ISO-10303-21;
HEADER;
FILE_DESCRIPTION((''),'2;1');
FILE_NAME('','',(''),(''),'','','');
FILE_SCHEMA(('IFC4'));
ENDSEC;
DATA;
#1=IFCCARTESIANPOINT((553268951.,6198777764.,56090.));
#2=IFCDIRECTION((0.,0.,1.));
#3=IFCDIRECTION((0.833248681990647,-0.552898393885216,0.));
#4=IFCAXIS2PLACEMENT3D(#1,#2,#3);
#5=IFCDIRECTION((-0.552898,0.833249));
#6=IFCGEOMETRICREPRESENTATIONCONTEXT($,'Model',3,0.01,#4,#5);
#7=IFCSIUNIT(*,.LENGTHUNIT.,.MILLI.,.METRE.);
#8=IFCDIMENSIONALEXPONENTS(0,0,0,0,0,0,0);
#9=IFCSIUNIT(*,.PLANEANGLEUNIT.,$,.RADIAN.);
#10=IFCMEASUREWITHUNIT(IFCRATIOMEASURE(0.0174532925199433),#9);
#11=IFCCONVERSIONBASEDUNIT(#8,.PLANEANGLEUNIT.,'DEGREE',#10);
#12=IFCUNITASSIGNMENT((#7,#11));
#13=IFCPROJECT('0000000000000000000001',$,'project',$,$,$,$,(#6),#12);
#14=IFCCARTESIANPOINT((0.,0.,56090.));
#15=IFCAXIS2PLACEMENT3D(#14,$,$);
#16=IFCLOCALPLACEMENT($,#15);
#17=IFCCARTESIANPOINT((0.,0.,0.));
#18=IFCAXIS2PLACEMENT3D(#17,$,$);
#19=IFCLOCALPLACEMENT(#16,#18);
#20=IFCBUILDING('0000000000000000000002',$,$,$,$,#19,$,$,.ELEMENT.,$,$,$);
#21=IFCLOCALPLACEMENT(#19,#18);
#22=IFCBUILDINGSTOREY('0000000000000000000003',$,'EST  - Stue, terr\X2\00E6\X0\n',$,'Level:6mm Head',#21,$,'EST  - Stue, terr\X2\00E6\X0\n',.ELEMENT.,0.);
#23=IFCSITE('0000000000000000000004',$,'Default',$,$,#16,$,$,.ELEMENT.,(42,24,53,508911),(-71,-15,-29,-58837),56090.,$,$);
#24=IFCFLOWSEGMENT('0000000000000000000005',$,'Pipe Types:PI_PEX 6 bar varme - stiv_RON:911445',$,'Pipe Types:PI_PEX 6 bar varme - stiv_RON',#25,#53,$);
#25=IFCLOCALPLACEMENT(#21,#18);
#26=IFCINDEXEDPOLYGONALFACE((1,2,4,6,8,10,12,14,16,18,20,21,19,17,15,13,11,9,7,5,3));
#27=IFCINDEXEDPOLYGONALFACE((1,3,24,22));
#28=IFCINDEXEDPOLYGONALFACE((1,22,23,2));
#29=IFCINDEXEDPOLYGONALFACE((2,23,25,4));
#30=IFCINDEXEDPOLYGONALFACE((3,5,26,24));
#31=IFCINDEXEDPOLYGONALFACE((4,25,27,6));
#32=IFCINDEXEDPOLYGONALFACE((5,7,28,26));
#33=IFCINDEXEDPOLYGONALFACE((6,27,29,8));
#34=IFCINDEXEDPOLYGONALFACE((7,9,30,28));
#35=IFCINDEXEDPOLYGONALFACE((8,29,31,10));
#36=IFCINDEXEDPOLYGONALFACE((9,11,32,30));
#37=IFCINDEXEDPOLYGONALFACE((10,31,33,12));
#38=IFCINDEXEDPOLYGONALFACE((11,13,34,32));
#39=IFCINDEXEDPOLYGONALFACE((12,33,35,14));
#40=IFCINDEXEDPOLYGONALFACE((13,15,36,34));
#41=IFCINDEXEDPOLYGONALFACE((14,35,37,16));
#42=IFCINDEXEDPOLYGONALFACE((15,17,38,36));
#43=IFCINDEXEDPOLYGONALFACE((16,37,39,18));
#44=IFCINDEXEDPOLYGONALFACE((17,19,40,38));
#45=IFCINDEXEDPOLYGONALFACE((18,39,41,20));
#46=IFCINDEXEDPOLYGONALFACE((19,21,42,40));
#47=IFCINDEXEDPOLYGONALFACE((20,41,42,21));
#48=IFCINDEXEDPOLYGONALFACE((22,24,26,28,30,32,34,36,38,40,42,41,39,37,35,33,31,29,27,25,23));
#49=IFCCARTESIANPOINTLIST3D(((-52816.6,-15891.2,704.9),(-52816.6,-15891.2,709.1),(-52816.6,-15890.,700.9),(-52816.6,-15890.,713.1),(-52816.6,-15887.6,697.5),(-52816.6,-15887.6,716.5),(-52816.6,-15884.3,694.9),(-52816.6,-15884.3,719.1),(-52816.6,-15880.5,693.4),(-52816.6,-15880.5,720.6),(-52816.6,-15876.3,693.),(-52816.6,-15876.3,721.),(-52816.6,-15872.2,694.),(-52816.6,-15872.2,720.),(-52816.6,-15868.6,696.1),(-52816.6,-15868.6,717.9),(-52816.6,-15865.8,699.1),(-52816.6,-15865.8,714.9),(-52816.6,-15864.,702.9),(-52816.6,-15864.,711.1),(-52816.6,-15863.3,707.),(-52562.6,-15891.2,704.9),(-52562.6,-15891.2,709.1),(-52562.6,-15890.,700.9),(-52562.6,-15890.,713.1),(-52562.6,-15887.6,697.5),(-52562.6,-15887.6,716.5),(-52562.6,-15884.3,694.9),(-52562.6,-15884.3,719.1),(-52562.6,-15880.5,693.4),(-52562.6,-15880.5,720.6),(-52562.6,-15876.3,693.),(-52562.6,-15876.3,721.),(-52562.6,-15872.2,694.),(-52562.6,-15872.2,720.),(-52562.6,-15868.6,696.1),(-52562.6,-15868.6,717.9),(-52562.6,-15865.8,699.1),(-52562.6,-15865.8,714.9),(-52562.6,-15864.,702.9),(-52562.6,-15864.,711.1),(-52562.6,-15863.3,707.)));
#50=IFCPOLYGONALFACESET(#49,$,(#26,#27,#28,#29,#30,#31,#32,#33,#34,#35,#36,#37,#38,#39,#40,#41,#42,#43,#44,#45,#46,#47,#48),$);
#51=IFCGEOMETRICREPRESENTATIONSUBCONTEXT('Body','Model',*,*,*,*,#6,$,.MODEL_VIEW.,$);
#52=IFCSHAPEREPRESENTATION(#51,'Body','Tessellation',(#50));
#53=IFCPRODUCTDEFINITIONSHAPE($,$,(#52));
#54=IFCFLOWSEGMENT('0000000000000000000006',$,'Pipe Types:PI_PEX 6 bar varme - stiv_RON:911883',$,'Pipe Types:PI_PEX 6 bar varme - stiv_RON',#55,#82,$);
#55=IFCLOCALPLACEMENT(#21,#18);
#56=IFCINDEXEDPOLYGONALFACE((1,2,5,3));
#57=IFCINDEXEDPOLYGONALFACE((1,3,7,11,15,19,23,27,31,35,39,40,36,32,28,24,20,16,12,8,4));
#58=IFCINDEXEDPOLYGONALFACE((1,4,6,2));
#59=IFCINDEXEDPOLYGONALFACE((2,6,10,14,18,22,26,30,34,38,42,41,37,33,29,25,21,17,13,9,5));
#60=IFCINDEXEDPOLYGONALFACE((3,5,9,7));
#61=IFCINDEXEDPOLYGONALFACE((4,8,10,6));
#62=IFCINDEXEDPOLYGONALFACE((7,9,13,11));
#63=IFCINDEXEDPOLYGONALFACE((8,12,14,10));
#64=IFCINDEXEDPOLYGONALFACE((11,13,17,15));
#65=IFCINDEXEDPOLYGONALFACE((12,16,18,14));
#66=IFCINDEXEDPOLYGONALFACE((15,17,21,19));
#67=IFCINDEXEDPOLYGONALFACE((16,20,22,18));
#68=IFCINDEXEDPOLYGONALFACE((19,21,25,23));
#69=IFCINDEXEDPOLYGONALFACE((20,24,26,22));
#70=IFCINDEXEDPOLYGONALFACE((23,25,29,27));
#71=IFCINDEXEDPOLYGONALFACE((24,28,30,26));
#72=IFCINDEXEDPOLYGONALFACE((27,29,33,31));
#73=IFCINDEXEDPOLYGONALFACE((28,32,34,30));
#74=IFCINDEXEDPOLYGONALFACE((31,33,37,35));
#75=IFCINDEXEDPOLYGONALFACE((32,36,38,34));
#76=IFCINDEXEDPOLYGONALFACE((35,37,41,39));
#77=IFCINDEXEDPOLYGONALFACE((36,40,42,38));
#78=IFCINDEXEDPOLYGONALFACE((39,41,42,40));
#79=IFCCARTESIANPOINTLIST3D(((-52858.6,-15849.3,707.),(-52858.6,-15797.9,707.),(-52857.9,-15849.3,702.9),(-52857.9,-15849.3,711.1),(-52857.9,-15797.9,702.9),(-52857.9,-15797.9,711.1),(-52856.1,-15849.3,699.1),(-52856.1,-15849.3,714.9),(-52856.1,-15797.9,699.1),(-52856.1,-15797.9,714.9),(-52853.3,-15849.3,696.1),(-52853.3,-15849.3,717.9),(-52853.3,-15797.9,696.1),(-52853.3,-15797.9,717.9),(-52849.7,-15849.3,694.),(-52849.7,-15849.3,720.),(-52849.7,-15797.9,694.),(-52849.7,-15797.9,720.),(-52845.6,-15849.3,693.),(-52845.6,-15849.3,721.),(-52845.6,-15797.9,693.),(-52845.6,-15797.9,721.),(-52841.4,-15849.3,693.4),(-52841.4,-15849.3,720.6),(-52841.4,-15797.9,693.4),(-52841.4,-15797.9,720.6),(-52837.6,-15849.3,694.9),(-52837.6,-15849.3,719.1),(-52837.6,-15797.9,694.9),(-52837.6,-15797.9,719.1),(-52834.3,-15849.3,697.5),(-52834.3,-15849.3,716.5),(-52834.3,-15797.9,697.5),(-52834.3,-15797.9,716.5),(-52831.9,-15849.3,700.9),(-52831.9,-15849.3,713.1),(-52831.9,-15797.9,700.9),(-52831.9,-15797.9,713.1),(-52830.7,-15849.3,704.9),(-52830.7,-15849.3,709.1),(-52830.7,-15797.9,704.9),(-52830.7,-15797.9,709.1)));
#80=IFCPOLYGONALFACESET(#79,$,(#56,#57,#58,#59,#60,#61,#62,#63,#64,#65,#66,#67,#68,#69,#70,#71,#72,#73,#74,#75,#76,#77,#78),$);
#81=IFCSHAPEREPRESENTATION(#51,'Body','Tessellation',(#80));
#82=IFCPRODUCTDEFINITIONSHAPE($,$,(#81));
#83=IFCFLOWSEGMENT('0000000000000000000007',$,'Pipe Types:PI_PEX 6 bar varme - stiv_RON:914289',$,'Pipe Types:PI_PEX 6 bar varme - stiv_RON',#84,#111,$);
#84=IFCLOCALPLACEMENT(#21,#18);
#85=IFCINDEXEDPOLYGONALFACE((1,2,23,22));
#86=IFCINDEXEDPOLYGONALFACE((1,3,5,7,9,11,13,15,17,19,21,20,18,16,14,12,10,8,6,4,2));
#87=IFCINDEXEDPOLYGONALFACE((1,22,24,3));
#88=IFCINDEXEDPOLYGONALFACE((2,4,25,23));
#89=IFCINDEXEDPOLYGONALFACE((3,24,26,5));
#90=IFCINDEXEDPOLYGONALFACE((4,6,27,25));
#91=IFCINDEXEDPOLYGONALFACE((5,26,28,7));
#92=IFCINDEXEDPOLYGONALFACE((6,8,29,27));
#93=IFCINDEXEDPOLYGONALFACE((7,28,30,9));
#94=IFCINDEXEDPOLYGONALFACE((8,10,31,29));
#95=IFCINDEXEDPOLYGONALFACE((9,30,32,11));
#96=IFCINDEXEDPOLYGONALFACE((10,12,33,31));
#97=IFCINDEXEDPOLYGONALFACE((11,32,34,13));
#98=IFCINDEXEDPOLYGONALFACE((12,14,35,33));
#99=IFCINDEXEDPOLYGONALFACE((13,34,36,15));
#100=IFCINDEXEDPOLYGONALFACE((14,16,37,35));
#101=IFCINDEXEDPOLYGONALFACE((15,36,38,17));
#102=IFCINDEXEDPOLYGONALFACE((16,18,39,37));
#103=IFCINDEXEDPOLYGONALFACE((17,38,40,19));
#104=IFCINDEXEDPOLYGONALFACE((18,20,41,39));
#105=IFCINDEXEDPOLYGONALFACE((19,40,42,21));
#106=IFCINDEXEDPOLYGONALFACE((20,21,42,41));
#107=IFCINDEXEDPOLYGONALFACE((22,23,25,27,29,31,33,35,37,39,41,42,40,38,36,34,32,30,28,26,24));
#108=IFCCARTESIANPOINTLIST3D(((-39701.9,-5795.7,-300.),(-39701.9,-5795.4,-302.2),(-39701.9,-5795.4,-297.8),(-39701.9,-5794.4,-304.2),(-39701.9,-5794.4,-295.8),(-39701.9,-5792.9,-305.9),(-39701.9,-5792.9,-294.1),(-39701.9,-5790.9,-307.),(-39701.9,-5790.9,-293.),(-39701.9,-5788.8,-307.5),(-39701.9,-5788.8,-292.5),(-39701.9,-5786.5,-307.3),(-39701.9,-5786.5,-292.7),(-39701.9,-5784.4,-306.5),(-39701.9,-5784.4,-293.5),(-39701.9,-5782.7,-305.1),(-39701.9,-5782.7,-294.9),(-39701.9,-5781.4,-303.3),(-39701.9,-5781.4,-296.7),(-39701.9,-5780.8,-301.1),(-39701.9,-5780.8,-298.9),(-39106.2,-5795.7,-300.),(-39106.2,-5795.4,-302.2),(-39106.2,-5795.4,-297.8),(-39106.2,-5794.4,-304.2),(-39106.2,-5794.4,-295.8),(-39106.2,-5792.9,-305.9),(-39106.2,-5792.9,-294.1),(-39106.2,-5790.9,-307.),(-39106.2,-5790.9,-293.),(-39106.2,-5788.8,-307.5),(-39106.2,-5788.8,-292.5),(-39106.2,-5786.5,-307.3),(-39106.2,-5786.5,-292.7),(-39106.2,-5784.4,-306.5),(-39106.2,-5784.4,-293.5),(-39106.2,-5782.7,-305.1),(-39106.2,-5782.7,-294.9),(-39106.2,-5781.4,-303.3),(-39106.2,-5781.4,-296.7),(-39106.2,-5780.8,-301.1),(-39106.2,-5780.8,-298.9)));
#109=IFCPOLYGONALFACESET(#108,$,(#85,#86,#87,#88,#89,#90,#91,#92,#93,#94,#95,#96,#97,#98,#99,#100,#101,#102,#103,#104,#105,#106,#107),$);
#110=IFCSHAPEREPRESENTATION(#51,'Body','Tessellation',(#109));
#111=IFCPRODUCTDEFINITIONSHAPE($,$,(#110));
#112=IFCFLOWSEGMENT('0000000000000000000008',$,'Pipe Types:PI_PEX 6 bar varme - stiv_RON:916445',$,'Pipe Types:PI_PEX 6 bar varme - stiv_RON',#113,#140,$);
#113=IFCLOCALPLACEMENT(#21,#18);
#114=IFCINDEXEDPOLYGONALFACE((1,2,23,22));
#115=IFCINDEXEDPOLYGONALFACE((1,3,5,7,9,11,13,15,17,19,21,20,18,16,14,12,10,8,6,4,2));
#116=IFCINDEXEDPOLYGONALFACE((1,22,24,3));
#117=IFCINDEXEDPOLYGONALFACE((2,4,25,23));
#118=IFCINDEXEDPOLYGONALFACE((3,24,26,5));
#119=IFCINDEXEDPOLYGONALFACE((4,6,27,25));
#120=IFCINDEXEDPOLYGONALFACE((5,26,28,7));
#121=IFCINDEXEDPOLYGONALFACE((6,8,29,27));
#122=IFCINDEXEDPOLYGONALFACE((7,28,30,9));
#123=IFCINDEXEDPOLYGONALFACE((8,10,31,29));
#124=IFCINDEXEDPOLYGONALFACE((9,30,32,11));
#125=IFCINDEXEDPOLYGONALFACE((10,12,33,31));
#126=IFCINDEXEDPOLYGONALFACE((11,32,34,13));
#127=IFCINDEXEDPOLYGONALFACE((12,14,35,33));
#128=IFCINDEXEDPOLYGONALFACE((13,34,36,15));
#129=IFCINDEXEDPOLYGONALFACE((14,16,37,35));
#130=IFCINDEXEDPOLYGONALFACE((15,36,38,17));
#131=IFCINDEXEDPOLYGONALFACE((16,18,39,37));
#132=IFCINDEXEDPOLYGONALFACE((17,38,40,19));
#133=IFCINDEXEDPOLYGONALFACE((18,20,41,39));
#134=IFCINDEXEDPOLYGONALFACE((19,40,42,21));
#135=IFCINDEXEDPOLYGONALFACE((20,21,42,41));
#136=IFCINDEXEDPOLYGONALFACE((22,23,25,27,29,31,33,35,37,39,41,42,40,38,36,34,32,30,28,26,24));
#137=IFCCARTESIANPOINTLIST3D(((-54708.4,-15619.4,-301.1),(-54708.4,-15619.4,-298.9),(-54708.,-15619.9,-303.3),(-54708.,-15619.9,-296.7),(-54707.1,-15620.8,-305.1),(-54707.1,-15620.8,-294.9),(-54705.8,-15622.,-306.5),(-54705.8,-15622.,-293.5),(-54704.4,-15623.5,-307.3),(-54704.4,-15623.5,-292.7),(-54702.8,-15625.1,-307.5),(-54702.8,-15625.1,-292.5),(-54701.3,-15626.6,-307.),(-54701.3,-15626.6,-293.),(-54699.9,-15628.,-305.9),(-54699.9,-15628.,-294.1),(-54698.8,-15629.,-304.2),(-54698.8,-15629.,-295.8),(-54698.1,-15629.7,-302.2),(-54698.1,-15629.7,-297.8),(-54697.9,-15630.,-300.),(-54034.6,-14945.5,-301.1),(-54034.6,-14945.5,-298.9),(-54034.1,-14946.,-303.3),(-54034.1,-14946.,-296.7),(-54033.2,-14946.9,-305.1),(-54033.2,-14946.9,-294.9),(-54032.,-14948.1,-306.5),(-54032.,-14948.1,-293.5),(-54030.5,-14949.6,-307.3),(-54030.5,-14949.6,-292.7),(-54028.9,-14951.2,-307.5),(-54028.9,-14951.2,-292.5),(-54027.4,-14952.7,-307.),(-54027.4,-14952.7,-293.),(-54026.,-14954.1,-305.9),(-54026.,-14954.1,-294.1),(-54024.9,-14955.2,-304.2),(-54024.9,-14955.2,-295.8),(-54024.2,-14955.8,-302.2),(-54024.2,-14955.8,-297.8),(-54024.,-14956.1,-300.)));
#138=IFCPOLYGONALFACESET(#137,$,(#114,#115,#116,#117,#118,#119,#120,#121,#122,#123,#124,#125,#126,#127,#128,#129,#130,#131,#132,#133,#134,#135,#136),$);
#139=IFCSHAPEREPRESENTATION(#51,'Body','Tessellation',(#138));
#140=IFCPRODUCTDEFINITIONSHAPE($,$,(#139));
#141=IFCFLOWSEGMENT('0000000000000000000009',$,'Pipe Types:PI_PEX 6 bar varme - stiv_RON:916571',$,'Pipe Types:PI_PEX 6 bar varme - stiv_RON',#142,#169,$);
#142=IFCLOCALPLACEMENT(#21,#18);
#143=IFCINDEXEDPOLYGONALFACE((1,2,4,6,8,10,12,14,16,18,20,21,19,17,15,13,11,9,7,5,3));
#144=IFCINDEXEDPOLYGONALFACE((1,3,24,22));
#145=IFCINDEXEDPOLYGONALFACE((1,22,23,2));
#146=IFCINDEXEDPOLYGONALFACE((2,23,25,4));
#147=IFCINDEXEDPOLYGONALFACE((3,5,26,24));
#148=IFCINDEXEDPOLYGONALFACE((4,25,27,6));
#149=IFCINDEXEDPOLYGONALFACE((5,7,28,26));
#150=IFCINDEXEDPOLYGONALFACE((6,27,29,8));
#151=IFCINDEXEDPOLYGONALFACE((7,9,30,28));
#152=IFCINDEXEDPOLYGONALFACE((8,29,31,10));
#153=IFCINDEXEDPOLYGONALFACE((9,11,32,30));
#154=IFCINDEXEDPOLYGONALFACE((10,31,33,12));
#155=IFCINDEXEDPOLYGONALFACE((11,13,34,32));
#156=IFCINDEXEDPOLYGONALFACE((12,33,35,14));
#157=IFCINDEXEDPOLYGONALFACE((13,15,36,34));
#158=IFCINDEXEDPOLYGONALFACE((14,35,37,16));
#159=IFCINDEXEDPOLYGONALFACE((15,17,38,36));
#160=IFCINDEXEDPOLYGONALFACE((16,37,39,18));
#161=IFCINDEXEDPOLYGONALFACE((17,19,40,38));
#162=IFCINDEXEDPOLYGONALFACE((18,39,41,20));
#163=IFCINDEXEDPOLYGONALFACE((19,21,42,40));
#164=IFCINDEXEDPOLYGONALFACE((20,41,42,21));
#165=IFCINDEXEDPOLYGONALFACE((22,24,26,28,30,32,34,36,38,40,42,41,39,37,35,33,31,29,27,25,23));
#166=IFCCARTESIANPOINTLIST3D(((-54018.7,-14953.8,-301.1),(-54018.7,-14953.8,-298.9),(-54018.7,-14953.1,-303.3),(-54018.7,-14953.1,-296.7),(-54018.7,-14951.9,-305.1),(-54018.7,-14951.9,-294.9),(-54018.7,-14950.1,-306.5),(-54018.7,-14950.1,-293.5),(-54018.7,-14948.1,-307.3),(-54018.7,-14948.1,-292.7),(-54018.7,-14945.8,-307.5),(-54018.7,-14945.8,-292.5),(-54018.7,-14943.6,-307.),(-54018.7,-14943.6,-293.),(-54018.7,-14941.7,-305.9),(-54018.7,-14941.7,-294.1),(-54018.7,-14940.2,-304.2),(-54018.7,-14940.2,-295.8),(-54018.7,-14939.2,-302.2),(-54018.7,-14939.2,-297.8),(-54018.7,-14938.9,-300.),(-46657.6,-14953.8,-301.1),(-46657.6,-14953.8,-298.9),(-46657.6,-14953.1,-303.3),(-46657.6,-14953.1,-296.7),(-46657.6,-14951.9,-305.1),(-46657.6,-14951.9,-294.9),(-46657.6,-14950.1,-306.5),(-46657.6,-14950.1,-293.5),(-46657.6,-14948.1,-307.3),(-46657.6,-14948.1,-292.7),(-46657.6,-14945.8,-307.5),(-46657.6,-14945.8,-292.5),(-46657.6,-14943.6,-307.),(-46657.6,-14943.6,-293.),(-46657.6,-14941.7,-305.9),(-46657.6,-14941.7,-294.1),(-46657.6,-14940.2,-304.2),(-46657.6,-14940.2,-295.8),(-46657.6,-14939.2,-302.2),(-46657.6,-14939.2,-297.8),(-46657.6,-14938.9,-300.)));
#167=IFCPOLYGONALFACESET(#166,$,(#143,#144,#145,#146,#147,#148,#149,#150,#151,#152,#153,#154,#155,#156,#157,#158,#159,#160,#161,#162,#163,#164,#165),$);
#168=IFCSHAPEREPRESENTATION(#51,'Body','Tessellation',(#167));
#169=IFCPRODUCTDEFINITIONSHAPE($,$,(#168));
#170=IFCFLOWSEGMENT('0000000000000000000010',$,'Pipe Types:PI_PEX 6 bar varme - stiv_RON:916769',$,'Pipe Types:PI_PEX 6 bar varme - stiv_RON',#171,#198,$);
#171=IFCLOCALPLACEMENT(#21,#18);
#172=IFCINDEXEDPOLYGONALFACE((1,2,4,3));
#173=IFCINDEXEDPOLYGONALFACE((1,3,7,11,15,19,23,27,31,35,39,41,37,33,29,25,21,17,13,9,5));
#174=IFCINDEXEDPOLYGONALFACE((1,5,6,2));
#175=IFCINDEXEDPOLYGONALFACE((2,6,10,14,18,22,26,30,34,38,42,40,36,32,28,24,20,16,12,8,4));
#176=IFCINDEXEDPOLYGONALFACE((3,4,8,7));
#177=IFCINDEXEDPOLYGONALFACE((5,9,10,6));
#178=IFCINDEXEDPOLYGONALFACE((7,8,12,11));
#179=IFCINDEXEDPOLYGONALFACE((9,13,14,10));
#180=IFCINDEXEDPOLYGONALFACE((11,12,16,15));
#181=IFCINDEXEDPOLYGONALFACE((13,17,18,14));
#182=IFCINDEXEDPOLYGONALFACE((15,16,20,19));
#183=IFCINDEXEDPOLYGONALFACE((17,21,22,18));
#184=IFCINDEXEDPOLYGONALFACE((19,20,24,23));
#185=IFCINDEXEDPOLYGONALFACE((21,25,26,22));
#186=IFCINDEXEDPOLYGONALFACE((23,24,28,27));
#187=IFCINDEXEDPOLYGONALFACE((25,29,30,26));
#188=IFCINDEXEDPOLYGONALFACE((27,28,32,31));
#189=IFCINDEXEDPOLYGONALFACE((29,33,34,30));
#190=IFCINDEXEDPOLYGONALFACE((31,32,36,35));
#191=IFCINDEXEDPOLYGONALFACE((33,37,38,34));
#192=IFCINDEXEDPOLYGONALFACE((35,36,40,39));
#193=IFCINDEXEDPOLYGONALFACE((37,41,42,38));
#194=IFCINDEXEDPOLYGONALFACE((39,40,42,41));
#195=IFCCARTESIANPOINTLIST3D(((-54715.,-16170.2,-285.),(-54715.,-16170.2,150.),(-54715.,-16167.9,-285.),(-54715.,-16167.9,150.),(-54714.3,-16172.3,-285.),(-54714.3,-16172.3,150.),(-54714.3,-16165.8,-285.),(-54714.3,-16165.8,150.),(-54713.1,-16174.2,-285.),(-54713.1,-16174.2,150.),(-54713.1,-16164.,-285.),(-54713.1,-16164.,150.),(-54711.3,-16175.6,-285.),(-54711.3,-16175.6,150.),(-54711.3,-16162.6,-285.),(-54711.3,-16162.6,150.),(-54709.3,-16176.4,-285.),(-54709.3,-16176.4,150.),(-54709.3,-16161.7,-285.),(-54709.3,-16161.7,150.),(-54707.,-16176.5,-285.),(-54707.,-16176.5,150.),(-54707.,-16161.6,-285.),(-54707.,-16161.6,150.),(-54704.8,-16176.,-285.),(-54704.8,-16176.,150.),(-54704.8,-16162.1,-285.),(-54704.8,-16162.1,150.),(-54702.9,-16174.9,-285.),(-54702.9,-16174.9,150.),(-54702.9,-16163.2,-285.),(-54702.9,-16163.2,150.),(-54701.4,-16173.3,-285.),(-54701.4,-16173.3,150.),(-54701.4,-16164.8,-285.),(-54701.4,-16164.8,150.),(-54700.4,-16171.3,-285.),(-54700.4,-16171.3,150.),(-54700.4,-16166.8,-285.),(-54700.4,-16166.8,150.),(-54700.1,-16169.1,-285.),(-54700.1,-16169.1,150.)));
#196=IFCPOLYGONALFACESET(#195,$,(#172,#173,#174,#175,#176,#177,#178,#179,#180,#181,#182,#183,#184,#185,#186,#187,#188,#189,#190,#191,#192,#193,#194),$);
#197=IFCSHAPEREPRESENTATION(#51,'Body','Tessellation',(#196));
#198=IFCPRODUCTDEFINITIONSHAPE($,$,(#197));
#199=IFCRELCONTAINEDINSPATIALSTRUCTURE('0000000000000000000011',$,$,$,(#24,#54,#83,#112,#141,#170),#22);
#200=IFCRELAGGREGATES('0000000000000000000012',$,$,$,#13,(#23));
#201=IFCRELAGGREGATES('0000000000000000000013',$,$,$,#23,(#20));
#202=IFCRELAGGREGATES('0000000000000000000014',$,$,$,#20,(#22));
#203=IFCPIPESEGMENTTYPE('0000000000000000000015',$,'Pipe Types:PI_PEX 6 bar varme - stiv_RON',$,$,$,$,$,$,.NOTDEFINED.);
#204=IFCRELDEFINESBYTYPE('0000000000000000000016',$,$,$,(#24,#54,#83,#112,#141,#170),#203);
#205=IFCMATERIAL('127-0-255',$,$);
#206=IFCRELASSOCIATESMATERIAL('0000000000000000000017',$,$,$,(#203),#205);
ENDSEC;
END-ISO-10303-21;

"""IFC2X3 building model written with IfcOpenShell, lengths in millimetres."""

from ifc_helpers import new_model, entity, si_unit, converted_unit, direction, frame, frame_2d, origin, origin_2d_with_axis, place, context, subcontext, project, spatial, circle, extrude, material, type_object, element, save


model = new_model("IFC2X3")

# Units and contexts
model_context = context("Model", 3, precision=0.01, world=frame((553268951.0, 6198777764.0, 56090.0), z_axis=(0.0, 0.0, 1.0), x_axis=(0.833248681990647, -0.552898393885216, 0.0)), true_north=direction((-0.552898, 0.833249)))
body_context = subcontext(model_context, "Body", "Model", "MODEL_VIEW")
ifc_project = project(units=[si_unit("LENGTHUNIT", "METRE", prefix="MILLI"), converted_unit("PLANEANGLEUNIT", "DEGREE", entity("IfcRatioMeasure", 0.0174532925199433), si_unit("PLANEANGLEUNIT", "RADIAN"), dimensions=[0, 0, 0, 0, 0, 0, 0])], contexts=[model_context])

# Site, building, storey
site_placement = place(None, frame((0.0, 0.0, 56090.0)))
site = spatial("IfcSite", under=ifc_project, at=site_placement, Name="Default", CompositionType="ELEMENT", RefLatitude=(42, 24, 53, 508911), RefLongitude=(-71, -15, -29, -58837), RefElevation=56090.0)
building_placement = place(site_placement, origin())
building = spatial("IfcBuilding", under=site, at=building_placement, CompositionType="ELEMENT")
storey_placement = place(building_placement, frame((0.0, 0.0, 0.0)))
storey = spatial("IfcBuildingStorey", under=building, at=storey_placement, Name="EST  - Stue, terræn", ObjectType="Level:6mm Head", LongName="EST  - Stue, terræn", CompositionType="ELEMENT", Elevation=0.0)

# Flow segments
ifc_material_1 = material(Name="127-0-255")
pipe_segment_type_1 = type_object("IfcPipeSegmentType", Name="Pipe Types:PI_PEX 6 bar varme - stiv_RON", PredefinedType="NOTDEFINED", material=ifc_material_1)
flow_segment_1_placement = place(storey_placement, origin())
element("IfcFlowSegment", 1, at=flow_segment_1_placement, inside=storey, type_object=pipe_segment_type_1, Name="Pipe Types:PI_PEX 6 bar varme - stiv_RON:911445", ObjectType="Pipe Types:PI_PEX 6 bar varme - stiv_RON", context=body_context, shape_type="SweptSolid", body=[
    extrude(circle(Radius=14.0, at=frame_2d((0.0, 0.0), x_axis=(1.0, 0.0))), frame((-52816.6, -15877.3, 707.0), z_axis=(1.0, 0.0, 0.0), x_axis=(0.0, 1.0, 0.0)), (0.0, 0.0, 1.0), 254.0),
])
flow_segment_2_placement = place(storey_placement, origin())
element("IfcFlowSegment", 2, at=flow_segment_2_placement, inside=storey, type_object=pipe_segment_type_1, Name="Pipe Types:PI_PEX 6 bar varme - stiv_RON:911883", ObjectType="Pipe Types:PI_PEX 6 bar varme - stiv_RON", context=body_context, shape_type="SweptSolid", body=[
    extrude(circle(Radius=14.0, at=origin_2d_with_axis()), frame((-52844.6, -15849.3, 707.0), z_axis=(0.0, 1.0, 0.0), x_axis=(-1.0, 0.0, 0.0)), (0.0, 0.0, 1.0), 51.5),
])
flow_segment_3_placement = place(storey_placement, origin())
element("IfcFlowSegment", 3, at=flow_segment_3_placement, inside=storey, type_object=pipe_segment_type_1, Name="Pipe Types:PI_PEX 6 bar varme - stiv_RON:914289", ObjectType="Pipe Types:PI_PEX 6 bar varme - stiv_RON", context=body_context, shape_type="SweptSolid", body=[
    extrude(circle(Radius=7.5, at=origin_2d_with_axis()), frame((-39701.9, -5788.2, -300.0), z_axis=(1.0, 0.0, 0.0), x_axis=(0.0, -1.0, 0.0)), (0.0, 0.0, 1.0), 595.7),
])
flow_segment_4_placement = place(storey_placement, origin())
element("IfcFlowSegment", 4, at=flow_segment_4_placement, inside=storey, type_object=pipe_segment_type_1, Name="Pipe Types:PI_PEX 6 bar varme - stiv_RON:916445", ObjectType="Pipe Types:PI_PEX 6 bar varme - stiv_RON", context=body_context, shape_type="SweptSolid", body=[
    extrude(circle(Radius=7.5, at=origin_2d_with_axis()), frame((-54703.2, -15624.7, -300.0), z_axis=(0.707107, 0.707107, 0.0), x_axis=(0.707107, -0.707107, 0.0)), (0.0, 0.0, 1.0), 953.0),
])
flow_segment_5_placement = place(storey_placement, origin())
element("IfcFlowSegment", 5, at=flow_segment_5_placement, inside=storey, type_object=pipe_segment_type_1, Name="Pipe Types:PI_PEX 6 bar varme - stiv_RON:916571", ObjectType="Pipe Types:PI_PEX 6 bar varme - stiv_RON", context=body_context, shape_type="SweptSolid", body=[
    extrude(circle(Radius=7.5, at=frame_2d((0.0, 0.0), x_axis=(1.0, 0.0))), frame((-54018.7, -14946.4, -300.0), z_axis=(1.0, 0.0, 0.0), x_axis=(0.0, 1.0, 0.0)), (0.0, 0.0, 1.0), 7361.1),
])
flow_segment_6_placement = place(storey_placement, origin())
element("IfcFlowSegment", 6, at=flow_segment_6_placement, inside=storey, type_object=pipe_segment_type_1, Name="Pipe Types:PI_PEX 6 bar varme - stiv_RON:916769", ObjectType="Pipe Types:PI_PEX 6 bar varme - stiv_RON", context=body_context, shape_type="SweptSolid", body=[
    extrude(circle(Radius=7.5, at=origin_2d_with_axis()), frame((-54707.6, -16169.1, -285.0)), (0.0, 0.0, 1.0), 435.0),
])

save(model, "model.ifc")
